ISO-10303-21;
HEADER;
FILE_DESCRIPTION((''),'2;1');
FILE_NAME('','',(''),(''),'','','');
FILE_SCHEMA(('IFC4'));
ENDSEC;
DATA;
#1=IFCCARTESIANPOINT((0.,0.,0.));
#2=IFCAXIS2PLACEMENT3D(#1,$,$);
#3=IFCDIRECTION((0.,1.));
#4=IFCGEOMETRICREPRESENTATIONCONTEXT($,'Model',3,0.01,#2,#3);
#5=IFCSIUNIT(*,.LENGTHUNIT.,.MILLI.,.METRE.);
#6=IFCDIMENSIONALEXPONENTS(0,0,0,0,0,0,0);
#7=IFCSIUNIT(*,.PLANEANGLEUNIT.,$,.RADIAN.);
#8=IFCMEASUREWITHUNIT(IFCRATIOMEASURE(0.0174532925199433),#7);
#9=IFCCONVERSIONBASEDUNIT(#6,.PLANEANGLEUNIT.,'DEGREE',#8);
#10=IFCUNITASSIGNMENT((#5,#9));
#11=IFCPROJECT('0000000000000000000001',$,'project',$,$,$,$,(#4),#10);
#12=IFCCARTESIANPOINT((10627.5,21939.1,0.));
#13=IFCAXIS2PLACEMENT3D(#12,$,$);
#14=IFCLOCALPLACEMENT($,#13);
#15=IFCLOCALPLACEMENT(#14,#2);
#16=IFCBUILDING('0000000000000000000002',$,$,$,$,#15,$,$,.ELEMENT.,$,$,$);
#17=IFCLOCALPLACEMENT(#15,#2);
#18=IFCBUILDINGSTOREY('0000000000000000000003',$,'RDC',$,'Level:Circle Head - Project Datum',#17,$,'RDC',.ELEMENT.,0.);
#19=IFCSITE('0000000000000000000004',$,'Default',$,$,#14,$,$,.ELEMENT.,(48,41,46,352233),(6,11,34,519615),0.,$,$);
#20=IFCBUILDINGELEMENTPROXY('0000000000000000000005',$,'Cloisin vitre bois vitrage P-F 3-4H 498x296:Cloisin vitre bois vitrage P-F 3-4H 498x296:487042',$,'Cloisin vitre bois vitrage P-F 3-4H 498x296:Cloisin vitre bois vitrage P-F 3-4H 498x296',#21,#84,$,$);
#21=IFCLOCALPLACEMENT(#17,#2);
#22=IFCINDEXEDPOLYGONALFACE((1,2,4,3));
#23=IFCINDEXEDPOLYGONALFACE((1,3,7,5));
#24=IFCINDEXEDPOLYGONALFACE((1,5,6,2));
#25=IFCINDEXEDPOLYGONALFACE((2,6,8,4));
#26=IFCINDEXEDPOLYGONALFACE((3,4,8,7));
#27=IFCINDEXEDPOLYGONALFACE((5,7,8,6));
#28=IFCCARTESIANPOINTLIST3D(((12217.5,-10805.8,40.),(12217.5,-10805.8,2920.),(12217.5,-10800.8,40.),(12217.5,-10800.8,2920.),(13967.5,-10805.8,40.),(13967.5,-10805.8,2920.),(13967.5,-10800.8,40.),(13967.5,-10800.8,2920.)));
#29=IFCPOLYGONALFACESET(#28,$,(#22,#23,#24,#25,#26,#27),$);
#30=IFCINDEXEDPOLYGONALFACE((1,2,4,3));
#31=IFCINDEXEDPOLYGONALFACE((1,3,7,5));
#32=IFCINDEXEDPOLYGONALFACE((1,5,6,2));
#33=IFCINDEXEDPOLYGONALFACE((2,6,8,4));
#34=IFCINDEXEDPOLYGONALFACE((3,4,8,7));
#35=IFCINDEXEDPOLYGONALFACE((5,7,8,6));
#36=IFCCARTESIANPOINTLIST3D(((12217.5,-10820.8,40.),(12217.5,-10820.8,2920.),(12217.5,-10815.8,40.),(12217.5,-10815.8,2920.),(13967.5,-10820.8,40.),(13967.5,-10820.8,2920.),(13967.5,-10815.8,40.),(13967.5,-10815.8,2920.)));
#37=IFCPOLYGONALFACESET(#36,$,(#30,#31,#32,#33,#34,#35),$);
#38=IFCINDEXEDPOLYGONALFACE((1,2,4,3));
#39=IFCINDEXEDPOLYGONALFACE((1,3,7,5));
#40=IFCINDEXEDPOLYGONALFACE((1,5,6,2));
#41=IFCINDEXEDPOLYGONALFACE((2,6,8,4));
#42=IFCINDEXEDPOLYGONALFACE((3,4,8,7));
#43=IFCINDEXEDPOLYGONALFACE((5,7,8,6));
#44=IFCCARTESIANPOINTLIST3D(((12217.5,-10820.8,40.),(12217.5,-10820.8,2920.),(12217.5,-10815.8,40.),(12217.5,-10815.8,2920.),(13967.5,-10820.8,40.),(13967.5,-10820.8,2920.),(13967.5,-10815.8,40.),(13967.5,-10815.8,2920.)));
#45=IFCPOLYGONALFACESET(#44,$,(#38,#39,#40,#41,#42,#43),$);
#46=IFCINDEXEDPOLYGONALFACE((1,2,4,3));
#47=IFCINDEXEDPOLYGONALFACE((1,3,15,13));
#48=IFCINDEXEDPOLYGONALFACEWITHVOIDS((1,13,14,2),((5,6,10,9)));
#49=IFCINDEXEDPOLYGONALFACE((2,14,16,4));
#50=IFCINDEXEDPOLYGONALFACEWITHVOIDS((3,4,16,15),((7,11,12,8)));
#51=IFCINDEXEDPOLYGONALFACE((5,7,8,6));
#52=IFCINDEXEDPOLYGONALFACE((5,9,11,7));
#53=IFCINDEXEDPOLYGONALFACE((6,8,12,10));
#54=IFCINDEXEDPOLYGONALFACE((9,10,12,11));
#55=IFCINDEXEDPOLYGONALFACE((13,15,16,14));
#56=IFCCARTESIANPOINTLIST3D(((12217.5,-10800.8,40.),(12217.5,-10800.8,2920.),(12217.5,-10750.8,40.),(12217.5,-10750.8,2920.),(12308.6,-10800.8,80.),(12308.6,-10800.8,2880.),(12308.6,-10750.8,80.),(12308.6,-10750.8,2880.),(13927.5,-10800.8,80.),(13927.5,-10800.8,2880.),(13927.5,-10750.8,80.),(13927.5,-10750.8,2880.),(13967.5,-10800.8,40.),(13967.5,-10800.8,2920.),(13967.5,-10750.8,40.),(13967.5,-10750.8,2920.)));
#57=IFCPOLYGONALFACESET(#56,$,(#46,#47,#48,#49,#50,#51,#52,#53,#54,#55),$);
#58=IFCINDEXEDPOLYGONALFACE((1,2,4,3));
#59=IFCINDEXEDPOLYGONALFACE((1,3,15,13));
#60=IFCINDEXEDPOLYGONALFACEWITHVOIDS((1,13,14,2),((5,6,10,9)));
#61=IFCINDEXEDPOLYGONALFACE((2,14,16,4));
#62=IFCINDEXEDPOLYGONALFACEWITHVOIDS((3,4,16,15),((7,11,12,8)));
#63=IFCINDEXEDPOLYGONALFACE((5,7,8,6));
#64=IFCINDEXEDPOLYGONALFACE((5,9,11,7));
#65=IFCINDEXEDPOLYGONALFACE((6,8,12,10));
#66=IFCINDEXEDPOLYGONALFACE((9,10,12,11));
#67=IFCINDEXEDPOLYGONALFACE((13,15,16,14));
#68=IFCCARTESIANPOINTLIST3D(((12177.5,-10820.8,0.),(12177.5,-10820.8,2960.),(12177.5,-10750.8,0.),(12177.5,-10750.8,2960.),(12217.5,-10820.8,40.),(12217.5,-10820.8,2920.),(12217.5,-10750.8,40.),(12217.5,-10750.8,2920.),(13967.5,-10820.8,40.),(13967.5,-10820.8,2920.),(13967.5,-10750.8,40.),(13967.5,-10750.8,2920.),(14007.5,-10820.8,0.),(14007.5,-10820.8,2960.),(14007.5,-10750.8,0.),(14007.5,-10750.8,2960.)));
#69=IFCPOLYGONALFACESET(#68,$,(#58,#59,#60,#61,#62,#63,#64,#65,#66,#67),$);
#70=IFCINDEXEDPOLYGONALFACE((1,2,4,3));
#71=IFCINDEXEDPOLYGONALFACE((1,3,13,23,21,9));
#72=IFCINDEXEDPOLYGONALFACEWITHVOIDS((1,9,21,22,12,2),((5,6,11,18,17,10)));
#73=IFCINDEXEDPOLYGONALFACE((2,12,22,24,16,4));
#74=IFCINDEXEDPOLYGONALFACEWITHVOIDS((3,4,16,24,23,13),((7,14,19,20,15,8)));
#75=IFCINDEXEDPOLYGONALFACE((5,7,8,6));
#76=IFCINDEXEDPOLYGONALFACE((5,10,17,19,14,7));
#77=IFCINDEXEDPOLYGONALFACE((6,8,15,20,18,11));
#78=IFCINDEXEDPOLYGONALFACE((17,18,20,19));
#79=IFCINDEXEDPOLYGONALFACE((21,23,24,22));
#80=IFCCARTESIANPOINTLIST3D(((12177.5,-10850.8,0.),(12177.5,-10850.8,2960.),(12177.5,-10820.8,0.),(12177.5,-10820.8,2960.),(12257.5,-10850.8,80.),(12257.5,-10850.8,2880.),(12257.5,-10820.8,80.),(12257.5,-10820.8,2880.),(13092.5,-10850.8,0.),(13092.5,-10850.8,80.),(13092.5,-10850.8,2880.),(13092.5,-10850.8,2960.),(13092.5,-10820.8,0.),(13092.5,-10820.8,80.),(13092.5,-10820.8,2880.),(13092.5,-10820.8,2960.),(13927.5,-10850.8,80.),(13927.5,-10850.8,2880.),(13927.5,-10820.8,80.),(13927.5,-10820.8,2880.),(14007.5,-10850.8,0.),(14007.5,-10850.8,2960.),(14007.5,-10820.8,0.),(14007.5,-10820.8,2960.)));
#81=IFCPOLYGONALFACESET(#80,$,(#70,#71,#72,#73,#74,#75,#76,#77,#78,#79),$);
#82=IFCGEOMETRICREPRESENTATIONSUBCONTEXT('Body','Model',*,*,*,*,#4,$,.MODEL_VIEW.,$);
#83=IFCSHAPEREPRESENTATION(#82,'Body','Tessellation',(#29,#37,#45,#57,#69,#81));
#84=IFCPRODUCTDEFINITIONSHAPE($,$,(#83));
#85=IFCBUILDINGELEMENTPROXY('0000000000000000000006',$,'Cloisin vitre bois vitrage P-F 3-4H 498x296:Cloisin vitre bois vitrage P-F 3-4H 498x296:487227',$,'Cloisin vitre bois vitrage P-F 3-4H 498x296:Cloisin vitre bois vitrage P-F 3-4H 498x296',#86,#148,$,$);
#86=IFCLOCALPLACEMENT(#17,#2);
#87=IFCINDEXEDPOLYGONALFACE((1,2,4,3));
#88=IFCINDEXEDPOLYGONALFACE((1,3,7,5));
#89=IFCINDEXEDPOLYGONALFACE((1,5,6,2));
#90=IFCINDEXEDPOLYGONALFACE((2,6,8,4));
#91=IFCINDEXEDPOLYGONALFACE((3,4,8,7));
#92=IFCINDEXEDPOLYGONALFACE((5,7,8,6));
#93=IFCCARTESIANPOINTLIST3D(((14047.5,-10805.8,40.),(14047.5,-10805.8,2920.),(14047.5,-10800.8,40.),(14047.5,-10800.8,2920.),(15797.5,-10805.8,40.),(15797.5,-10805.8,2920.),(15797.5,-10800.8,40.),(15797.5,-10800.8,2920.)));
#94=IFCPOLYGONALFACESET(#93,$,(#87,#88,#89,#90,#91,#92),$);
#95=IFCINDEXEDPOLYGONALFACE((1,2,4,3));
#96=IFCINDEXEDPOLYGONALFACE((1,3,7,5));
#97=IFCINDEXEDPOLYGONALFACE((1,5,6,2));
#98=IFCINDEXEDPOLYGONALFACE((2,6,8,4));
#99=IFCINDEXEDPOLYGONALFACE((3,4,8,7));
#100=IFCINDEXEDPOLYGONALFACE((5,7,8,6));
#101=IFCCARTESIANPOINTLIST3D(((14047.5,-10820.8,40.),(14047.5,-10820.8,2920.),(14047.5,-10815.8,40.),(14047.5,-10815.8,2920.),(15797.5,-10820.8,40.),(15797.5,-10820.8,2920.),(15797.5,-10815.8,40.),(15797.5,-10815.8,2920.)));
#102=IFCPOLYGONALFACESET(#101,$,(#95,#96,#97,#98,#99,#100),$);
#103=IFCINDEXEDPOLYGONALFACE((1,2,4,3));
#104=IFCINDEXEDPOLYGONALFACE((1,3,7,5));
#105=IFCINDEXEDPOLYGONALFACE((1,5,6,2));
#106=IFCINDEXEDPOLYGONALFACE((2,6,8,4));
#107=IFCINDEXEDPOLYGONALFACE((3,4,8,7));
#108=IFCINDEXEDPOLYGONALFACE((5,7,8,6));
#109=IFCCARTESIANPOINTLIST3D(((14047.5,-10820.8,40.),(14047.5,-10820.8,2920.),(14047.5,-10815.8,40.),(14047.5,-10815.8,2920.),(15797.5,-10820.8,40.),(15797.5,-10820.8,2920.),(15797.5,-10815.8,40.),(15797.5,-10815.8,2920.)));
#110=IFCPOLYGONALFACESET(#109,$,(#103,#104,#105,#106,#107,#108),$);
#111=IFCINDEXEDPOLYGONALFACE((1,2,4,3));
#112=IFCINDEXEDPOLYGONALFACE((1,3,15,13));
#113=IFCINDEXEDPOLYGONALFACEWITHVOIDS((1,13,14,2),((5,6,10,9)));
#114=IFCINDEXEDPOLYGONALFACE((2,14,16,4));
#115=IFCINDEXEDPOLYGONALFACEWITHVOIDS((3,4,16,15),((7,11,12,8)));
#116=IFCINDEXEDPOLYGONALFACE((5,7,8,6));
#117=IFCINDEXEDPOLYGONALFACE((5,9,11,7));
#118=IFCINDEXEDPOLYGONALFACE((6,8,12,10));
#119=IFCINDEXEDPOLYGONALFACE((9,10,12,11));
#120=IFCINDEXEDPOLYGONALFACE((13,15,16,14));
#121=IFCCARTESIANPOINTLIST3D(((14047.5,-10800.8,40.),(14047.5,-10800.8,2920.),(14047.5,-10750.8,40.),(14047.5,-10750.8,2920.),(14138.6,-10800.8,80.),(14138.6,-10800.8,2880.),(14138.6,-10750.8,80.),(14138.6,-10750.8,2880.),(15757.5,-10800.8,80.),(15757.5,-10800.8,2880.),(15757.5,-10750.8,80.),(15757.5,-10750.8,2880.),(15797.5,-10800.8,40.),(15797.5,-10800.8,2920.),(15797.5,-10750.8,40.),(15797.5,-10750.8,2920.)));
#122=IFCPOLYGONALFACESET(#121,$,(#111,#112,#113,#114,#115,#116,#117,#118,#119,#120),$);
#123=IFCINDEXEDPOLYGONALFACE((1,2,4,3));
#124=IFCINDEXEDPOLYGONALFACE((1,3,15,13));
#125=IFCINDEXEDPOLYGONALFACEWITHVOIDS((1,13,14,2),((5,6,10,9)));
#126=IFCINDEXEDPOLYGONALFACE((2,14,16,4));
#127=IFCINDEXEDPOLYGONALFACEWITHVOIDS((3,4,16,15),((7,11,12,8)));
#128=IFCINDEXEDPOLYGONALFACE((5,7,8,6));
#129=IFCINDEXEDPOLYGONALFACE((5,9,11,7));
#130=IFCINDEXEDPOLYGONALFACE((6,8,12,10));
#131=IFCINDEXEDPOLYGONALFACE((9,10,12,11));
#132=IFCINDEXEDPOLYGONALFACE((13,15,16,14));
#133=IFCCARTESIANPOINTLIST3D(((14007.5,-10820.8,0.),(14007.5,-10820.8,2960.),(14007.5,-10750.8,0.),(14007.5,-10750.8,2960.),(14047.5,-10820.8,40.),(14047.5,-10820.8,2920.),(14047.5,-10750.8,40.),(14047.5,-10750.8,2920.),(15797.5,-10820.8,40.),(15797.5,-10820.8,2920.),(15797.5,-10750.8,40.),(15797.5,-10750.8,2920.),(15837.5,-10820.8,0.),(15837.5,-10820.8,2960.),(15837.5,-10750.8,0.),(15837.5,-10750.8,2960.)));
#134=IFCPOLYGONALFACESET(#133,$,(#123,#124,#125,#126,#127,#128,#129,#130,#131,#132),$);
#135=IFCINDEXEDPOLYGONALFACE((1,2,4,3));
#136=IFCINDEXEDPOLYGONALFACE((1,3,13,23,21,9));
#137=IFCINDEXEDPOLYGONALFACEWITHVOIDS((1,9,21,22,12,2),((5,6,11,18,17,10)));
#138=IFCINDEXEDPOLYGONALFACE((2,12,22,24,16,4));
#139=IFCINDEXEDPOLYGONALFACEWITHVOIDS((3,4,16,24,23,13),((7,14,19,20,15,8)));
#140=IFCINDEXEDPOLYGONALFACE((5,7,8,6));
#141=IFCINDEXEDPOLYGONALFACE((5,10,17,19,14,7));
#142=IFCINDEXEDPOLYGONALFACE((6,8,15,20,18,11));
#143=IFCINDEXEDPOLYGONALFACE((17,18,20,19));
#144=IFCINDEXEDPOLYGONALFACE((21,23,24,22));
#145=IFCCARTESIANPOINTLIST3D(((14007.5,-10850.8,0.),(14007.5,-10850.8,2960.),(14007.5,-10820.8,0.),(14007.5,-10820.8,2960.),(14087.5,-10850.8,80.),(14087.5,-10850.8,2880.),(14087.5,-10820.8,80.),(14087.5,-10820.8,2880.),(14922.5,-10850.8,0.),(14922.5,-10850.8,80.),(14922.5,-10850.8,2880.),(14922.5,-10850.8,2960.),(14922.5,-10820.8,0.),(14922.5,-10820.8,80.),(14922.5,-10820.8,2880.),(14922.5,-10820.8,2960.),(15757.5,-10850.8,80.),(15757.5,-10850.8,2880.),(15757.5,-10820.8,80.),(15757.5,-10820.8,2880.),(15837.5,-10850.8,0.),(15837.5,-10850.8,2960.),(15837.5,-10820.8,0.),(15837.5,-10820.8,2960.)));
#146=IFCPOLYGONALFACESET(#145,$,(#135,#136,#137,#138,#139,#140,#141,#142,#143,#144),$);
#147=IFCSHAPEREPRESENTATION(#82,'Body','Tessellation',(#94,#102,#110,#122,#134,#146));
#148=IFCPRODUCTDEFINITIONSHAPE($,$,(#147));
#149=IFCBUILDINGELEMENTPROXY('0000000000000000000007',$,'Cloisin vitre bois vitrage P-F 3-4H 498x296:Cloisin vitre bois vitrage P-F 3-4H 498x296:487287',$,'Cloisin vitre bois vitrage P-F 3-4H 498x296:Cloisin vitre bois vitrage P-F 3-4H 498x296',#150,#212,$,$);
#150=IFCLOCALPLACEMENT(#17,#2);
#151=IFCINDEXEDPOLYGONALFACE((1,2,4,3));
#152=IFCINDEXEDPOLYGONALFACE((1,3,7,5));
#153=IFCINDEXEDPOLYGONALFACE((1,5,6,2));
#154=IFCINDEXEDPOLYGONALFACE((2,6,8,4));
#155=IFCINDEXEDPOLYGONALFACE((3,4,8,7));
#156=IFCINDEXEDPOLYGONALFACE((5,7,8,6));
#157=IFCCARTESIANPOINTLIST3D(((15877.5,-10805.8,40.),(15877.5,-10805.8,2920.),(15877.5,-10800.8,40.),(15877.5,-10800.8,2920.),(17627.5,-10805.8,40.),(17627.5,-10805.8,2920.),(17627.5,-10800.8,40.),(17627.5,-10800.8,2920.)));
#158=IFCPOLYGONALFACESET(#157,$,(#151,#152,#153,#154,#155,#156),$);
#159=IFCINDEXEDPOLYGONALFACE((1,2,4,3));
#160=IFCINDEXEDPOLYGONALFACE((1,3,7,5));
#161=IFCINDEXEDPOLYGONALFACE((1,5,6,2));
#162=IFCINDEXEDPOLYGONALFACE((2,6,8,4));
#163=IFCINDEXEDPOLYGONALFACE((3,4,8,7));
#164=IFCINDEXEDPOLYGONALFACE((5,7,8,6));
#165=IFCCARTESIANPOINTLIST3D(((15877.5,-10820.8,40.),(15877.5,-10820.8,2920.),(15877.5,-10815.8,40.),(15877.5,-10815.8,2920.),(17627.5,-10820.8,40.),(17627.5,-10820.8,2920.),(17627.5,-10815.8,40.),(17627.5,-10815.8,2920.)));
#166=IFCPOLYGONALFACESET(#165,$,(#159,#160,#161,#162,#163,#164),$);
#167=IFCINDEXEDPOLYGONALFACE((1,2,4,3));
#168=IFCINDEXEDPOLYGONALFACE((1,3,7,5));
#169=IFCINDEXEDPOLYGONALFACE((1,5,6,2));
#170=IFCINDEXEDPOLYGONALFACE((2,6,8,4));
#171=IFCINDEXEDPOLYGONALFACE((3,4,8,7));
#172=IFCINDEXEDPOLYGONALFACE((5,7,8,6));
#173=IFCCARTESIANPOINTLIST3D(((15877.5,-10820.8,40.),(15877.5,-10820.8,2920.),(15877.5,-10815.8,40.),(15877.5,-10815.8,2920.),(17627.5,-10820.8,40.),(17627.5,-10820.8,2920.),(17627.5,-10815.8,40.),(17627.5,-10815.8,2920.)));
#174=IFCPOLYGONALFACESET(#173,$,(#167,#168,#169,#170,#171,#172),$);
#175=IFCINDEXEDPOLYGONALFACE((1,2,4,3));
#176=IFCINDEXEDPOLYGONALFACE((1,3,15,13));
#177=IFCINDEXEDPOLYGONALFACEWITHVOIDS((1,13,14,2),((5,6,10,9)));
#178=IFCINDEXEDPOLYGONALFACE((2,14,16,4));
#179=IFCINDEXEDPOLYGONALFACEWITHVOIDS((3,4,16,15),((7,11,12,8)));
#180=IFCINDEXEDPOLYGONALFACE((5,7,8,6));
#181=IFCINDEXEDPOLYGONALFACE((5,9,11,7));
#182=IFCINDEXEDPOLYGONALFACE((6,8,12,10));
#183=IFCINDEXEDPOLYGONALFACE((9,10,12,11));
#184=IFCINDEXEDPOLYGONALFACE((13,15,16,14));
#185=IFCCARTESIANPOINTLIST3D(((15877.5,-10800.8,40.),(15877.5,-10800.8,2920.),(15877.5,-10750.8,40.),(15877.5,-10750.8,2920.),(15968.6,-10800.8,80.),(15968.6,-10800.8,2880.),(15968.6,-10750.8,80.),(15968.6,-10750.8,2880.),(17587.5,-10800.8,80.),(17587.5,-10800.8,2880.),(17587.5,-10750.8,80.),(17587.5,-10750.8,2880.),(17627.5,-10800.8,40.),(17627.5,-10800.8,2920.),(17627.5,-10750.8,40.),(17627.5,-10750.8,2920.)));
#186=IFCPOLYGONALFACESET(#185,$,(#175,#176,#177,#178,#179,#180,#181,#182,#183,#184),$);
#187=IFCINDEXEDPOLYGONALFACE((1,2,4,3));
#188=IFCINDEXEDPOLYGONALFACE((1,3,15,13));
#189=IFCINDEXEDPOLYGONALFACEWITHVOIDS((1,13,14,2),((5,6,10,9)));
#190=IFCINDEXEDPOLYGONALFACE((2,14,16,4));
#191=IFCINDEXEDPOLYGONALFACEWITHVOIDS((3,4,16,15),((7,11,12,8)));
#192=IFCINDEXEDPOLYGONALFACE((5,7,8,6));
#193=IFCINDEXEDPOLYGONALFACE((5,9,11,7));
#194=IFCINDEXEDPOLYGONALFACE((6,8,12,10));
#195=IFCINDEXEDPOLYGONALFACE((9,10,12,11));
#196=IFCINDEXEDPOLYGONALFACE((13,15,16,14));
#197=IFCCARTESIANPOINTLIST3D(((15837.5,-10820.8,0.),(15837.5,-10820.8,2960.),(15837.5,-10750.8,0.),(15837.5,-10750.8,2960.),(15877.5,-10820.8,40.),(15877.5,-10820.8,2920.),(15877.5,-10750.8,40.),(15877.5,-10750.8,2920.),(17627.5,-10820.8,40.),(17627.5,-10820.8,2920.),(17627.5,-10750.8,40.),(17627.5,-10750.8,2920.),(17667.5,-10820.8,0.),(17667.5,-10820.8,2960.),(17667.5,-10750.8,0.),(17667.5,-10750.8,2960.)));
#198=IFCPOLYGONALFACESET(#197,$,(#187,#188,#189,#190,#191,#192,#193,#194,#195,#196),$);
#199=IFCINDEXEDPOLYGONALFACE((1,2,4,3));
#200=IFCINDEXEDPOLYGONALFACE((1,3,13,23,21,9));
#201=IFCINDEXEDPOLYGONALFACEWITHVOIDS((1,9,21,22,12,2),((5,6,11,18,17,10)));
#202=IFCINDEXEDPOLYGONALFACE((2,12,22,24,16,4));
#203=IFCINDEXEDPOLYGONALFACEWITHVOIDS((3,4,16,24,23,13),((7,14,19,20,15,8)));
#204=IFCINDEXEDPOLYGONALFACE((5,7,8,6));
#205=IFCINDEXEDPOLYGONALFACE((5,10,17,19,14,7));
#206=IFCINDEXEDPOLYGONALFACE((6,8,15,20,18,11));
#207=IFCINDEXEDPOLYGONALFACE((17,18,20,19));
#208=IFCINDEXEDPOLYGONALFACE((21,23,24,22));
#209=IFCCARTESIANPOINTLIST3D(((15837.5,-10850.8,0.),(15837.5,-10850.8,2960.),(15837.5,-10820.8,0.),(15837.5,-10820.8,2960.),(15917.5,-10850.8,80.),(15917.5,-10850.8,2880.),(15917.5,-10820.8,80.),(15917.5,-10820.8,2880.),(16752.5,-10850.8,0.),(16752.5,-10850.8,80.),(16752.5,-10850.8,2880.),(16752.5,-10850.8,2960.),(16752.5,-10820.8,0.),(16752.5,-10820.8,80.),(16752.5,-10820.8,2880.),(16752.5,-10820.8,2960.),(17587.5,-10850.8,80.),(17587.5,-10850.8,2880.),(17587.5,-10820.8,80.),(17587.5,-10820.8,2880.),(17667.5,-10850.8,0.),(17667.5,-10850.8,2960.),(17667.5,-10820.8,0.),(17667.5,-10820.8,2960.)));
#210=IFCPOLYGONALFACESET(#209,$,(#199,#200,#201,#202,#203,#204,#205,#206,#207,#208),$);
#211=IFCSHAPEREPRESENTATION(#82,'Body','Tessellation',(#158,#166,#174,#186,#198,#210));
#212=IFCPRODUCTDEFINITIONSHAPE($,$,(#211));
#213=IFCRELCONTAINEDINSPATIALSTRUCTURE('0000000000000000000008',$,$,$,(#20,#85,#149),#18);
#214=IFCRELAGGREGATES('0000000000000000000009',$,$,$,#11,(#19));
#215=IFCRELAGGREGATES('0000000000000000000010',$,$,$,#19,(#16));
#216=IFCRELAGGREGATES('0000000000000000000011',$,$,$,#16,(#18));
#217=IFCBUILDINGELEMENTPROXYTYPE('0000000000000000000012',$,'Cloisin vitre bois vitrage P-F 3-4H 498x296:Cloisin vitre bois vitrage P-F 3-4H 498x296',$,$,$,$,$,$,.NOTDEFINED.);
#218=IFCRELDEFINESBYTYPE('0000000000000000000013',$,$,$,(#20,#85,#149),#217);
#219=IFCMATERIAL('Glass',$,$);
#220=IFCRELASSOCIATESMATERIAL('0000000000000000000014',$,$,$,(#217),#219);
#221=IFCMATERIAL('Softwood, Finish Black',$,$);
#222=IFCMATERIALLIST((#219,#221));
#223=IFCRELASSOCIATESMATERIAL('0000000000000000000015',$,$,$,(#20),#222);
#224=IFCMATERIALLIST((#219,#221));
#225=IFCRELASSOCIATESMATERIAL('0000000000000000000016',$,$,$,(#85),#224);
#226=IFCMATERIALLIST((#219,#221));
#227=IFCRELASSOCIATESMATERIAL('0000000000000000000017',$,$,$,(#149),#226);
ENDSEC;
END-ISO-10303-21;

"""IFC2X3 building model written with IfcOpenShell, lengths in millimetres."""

from ifc_helpers import new_model, entity, si_unit, converted_unit, direction, frame, frame_2d, origin, place, context, subcontext, project, spatial, polyline, rectangle, outline, extrude, source, transform, mapped, material, material_list, type_object, type_shapes, element, save


model = new_model("IFC2X3")

# Units and contexts
model_context = context("Model", 3, precision=0.01, world=origin(), true_north=direction((0.0, 1.0)))
body_context = subcontext(model_context, "Body", "Model", "MODEL_VIEW")
ifc_project = project(units=[si_unit("LENGTHUNIT", "METRE", prefix="MILLI"), converted_unit("PLANEANGLEUNIT", "DEGREE", entity("IfcRatioMeasure", 0.0174532925199433), si_unit("PLANEANGLEUNIT", "RADIAN"), dimensions=[0, 0, 0, 0, 0, 0, 0])], contexts=[model_context])

# Site, building, storey
site_placement = place(None, frame((10627.5, 21939.1, 0.0)))
site = spatial("IfcSite", under=ifc_project, at=site_placement, Name="Default", CompositionType="ELEMENT", RefLatitude=(48, 41, 46, 352233), RefLongitude=(6, 11, 34, 519615), RefElevation=0.0)
building_placement = place(site_placement, origin())
building = spatial("IfcBuilding", under=site, at=building_placement, CompositionType="ELEMENT")
storey_placement = place(building_placement, origin())
storey = spatial("IfcBuildingStorey", under=building, at=storey_placement, Name="RDC", ObjectType="Level:Circle Head - Project Datum", LongName="RDC", CompositionType="ELEMENT", Elevation=0.0)

# Building element proxies
ifc_material_1 = material(Name="Glass")
ifc_material_2 = material(Name="Softwood, Finish Black")
building_element_proxy_type_1 = type_object("IfcBuildingElementProxyType", Name="Cloisin vitre bois vitrage P-F 3-4H 498x296:Cloisin vitre bois vitrage P-F 3-4H 498x296", PredefinedType="NOTDEFINED", material=ifc_material_1)
shared_shape_1 = source(origin(), body_context, "Body", "SweptSolid", [
    extrude(rectangle(XDim=5.0, YDim=1750.0, at=frame_2d((0.0, 0.0), x_axis=(1.0, 0.0))), frame((0.0, -47.5, 40.0), z_axis=(0.0, 0.0, 1.0), x_axis=(0.0, 1.0, 0.0)), (0.0, 0.0, 1.0), 2880.0),
    extrude(rectangle(XDim=5.0, YDim=1750.0, at=frame_2d((0.0, 0.0), x_axis=(1.0, 0.0))), frame((0.0, -32.5, 40.0), z_axis=(0.0, 0.0, 1.0), x_axis=(0.0, 1.0, 0.0)), (0.0, 0.0, 1.0), 2880.0),
    extrude(rectangle(XDim=5.0, YDim=1750.0, at=frame_2d((0.0, 0.0), x_axis=(1.0, 0.0))), frame((0.0, -32.5, 40.0), z_axis=(0.0, 0.0, 1.0), x_axis=(0.0, 1.0, 0.0)), (0.0, 0.0, 1.0), 2880.0),
    extrude(outline(polyline([(-1440.0, -875.0), (1440.0, -875.0), (1440.0, 875.0), (-1440.0, 875.0), (-1440.0, -875.0)]), holes=[polyline([(1400.0, 835.0), (1400.0, -783.9), (-1400.0, -783.9), (-1400.0, 835.0), (1400.0, 835.0)])]), frame((0.0, -100.0, 1480.0), z_axis=(0.0, 1.0, 0.0), x_axis=(0.0, 0.0, -1.0)), (0.0, 0.0, 1.0), 50.0),
    extrude(outline(polyline([(-1480.0, -915.0), (1480.0, -915.0), (1480.0, 915.0), (-1480.0, 915.0), (-1480.0, -915.0)]), holes=[polyline([(-1440.0, -875.0), (-1440.0, 875.0), (1440.0, 875.0), (1440.0, -875.0), (-1440.0, -875.0)])]), frame((0.0, -100.0, 1480.0), z_axis=(0.0, 1.0, 0.0), x_axis=(0.0, 0.0, -1.0)), (0.0, 0.0, 1.0), 70.0),
    extrude(outline(polyline([(-1480.0, -915.0), (1480.0, -915.0), (1480.0, 0.0), (1480.0, 915.0), (-1480.0, 915.0), (-1480.0, 0.0), (-1480.0, -915.0)]), holes=[polyline([(1400.0, 0.0), (1400.0, -835.0), (-1400.0, -835.0), (-1400.0, 0.0), (-1400.0, 835.0), (1400.0, 835.0), (1400.0, 0.0)])]), frame((0.0, -30.0, 1480.0), z_axis=(0.0, 1.0, 0.0), x_axis=(0.0, 0.0, 1.0)), (0.0, 0.0, 1.0), 30.0),
])
type_shapes(building_element_proxy_type_1, [shared_shape_1])
ifc_material_list_1 = material_list([ifc_material_1, ifc_material_2])
proxy_1_placement = place(storey_placement, frame((13092.5, -10850.8, 0.0), z_axis=(0.0, 0.0, 1.0), x_axis=(-1.0, 0.0, 0.0)))
element("IfcBuildingElementProxy", 1, at=proxy_1_placement, inside=storey, type_object=building_element_proxy_type_1, material=ifc_material_list_1, Name="Cloisin vitre bois vitrage P-F 3-4H 498x296:Cloisin vitre bois vitrage P-F 3-4H 498x296:487042", ObjectType="Cloisin vitre bois vitrage P-F 3-4H 498x296:Cloisin vitre bois vitrage P-F 3-4H 498x296", context=body_context, shape_type="MappedRepresentation", body=[
    mapped(shared_shape_1, transform((0.0, 0.0, 0.0), scale=1.0)),
])
ifc_material_list_2 = material_list([ifc_material_1, ifc_material_2])
proxy_2_placement = place(storey_placement, frame((14922.5, -10850.8, 0.0), z_axis=(0.0, 0.0, 1.0), x_axis=(-1.0, 0.0, 0.0)))
element("IfcBuildingElementProxy", 2, at=proxy_2_placement, inside=storey, type_object=building_element_proxy_type_1, material=ifc_material_list_2, Name="Cloisin vitre bois vitrage P-F 3-4H 498x296:Cloisin vitre bois vitrage P-F 3-4H 498x296:487227", ObjectType="Cloisin vitre bois vitrage P-F 3-4H 498x296:Cloisin vitre bois vitrage P-F 3-4H 498x296", context=body_context, shape_type="MappedRepresentation", body=[
    mapped(shared_shape_1, transform((0.0, 0.0, 0.0), scale=1.0)),
])
ifc_material_list_3 = material_list([ifc_material_1, ifc_material_2])
proxy_3_placement = place(storey_placement, frame((16752.5, -10850.8, 0.0), z_axis=(0.0, 0.0, 1.0), x_axis=(-1.0, 0.0, 0.0)))
element("IfcBuildingElementProxy", 3, at=proxy_3_placement, inside=storey, type_object=building_element_proxy_type_1, material=ifc_material_list_3, Name="Cloisin vitre bois vitrage P-F 3-4H 498x296:Cloisin vitre bois vitrage P-F 3-4H 498x296:487287", ObjectType="Cloisin vitre bois vitrage P-F 3-4H 498x296:Cloisin vitre bois vitrage P-F 3-4H 498x296", context=body_context, shape_type="MappedRepresentation", body=[
    mapped(shared_shape_1, transform((0.0, 0.0, 0.0), scale=1.0)),
])

save(model, "model.ifc")
